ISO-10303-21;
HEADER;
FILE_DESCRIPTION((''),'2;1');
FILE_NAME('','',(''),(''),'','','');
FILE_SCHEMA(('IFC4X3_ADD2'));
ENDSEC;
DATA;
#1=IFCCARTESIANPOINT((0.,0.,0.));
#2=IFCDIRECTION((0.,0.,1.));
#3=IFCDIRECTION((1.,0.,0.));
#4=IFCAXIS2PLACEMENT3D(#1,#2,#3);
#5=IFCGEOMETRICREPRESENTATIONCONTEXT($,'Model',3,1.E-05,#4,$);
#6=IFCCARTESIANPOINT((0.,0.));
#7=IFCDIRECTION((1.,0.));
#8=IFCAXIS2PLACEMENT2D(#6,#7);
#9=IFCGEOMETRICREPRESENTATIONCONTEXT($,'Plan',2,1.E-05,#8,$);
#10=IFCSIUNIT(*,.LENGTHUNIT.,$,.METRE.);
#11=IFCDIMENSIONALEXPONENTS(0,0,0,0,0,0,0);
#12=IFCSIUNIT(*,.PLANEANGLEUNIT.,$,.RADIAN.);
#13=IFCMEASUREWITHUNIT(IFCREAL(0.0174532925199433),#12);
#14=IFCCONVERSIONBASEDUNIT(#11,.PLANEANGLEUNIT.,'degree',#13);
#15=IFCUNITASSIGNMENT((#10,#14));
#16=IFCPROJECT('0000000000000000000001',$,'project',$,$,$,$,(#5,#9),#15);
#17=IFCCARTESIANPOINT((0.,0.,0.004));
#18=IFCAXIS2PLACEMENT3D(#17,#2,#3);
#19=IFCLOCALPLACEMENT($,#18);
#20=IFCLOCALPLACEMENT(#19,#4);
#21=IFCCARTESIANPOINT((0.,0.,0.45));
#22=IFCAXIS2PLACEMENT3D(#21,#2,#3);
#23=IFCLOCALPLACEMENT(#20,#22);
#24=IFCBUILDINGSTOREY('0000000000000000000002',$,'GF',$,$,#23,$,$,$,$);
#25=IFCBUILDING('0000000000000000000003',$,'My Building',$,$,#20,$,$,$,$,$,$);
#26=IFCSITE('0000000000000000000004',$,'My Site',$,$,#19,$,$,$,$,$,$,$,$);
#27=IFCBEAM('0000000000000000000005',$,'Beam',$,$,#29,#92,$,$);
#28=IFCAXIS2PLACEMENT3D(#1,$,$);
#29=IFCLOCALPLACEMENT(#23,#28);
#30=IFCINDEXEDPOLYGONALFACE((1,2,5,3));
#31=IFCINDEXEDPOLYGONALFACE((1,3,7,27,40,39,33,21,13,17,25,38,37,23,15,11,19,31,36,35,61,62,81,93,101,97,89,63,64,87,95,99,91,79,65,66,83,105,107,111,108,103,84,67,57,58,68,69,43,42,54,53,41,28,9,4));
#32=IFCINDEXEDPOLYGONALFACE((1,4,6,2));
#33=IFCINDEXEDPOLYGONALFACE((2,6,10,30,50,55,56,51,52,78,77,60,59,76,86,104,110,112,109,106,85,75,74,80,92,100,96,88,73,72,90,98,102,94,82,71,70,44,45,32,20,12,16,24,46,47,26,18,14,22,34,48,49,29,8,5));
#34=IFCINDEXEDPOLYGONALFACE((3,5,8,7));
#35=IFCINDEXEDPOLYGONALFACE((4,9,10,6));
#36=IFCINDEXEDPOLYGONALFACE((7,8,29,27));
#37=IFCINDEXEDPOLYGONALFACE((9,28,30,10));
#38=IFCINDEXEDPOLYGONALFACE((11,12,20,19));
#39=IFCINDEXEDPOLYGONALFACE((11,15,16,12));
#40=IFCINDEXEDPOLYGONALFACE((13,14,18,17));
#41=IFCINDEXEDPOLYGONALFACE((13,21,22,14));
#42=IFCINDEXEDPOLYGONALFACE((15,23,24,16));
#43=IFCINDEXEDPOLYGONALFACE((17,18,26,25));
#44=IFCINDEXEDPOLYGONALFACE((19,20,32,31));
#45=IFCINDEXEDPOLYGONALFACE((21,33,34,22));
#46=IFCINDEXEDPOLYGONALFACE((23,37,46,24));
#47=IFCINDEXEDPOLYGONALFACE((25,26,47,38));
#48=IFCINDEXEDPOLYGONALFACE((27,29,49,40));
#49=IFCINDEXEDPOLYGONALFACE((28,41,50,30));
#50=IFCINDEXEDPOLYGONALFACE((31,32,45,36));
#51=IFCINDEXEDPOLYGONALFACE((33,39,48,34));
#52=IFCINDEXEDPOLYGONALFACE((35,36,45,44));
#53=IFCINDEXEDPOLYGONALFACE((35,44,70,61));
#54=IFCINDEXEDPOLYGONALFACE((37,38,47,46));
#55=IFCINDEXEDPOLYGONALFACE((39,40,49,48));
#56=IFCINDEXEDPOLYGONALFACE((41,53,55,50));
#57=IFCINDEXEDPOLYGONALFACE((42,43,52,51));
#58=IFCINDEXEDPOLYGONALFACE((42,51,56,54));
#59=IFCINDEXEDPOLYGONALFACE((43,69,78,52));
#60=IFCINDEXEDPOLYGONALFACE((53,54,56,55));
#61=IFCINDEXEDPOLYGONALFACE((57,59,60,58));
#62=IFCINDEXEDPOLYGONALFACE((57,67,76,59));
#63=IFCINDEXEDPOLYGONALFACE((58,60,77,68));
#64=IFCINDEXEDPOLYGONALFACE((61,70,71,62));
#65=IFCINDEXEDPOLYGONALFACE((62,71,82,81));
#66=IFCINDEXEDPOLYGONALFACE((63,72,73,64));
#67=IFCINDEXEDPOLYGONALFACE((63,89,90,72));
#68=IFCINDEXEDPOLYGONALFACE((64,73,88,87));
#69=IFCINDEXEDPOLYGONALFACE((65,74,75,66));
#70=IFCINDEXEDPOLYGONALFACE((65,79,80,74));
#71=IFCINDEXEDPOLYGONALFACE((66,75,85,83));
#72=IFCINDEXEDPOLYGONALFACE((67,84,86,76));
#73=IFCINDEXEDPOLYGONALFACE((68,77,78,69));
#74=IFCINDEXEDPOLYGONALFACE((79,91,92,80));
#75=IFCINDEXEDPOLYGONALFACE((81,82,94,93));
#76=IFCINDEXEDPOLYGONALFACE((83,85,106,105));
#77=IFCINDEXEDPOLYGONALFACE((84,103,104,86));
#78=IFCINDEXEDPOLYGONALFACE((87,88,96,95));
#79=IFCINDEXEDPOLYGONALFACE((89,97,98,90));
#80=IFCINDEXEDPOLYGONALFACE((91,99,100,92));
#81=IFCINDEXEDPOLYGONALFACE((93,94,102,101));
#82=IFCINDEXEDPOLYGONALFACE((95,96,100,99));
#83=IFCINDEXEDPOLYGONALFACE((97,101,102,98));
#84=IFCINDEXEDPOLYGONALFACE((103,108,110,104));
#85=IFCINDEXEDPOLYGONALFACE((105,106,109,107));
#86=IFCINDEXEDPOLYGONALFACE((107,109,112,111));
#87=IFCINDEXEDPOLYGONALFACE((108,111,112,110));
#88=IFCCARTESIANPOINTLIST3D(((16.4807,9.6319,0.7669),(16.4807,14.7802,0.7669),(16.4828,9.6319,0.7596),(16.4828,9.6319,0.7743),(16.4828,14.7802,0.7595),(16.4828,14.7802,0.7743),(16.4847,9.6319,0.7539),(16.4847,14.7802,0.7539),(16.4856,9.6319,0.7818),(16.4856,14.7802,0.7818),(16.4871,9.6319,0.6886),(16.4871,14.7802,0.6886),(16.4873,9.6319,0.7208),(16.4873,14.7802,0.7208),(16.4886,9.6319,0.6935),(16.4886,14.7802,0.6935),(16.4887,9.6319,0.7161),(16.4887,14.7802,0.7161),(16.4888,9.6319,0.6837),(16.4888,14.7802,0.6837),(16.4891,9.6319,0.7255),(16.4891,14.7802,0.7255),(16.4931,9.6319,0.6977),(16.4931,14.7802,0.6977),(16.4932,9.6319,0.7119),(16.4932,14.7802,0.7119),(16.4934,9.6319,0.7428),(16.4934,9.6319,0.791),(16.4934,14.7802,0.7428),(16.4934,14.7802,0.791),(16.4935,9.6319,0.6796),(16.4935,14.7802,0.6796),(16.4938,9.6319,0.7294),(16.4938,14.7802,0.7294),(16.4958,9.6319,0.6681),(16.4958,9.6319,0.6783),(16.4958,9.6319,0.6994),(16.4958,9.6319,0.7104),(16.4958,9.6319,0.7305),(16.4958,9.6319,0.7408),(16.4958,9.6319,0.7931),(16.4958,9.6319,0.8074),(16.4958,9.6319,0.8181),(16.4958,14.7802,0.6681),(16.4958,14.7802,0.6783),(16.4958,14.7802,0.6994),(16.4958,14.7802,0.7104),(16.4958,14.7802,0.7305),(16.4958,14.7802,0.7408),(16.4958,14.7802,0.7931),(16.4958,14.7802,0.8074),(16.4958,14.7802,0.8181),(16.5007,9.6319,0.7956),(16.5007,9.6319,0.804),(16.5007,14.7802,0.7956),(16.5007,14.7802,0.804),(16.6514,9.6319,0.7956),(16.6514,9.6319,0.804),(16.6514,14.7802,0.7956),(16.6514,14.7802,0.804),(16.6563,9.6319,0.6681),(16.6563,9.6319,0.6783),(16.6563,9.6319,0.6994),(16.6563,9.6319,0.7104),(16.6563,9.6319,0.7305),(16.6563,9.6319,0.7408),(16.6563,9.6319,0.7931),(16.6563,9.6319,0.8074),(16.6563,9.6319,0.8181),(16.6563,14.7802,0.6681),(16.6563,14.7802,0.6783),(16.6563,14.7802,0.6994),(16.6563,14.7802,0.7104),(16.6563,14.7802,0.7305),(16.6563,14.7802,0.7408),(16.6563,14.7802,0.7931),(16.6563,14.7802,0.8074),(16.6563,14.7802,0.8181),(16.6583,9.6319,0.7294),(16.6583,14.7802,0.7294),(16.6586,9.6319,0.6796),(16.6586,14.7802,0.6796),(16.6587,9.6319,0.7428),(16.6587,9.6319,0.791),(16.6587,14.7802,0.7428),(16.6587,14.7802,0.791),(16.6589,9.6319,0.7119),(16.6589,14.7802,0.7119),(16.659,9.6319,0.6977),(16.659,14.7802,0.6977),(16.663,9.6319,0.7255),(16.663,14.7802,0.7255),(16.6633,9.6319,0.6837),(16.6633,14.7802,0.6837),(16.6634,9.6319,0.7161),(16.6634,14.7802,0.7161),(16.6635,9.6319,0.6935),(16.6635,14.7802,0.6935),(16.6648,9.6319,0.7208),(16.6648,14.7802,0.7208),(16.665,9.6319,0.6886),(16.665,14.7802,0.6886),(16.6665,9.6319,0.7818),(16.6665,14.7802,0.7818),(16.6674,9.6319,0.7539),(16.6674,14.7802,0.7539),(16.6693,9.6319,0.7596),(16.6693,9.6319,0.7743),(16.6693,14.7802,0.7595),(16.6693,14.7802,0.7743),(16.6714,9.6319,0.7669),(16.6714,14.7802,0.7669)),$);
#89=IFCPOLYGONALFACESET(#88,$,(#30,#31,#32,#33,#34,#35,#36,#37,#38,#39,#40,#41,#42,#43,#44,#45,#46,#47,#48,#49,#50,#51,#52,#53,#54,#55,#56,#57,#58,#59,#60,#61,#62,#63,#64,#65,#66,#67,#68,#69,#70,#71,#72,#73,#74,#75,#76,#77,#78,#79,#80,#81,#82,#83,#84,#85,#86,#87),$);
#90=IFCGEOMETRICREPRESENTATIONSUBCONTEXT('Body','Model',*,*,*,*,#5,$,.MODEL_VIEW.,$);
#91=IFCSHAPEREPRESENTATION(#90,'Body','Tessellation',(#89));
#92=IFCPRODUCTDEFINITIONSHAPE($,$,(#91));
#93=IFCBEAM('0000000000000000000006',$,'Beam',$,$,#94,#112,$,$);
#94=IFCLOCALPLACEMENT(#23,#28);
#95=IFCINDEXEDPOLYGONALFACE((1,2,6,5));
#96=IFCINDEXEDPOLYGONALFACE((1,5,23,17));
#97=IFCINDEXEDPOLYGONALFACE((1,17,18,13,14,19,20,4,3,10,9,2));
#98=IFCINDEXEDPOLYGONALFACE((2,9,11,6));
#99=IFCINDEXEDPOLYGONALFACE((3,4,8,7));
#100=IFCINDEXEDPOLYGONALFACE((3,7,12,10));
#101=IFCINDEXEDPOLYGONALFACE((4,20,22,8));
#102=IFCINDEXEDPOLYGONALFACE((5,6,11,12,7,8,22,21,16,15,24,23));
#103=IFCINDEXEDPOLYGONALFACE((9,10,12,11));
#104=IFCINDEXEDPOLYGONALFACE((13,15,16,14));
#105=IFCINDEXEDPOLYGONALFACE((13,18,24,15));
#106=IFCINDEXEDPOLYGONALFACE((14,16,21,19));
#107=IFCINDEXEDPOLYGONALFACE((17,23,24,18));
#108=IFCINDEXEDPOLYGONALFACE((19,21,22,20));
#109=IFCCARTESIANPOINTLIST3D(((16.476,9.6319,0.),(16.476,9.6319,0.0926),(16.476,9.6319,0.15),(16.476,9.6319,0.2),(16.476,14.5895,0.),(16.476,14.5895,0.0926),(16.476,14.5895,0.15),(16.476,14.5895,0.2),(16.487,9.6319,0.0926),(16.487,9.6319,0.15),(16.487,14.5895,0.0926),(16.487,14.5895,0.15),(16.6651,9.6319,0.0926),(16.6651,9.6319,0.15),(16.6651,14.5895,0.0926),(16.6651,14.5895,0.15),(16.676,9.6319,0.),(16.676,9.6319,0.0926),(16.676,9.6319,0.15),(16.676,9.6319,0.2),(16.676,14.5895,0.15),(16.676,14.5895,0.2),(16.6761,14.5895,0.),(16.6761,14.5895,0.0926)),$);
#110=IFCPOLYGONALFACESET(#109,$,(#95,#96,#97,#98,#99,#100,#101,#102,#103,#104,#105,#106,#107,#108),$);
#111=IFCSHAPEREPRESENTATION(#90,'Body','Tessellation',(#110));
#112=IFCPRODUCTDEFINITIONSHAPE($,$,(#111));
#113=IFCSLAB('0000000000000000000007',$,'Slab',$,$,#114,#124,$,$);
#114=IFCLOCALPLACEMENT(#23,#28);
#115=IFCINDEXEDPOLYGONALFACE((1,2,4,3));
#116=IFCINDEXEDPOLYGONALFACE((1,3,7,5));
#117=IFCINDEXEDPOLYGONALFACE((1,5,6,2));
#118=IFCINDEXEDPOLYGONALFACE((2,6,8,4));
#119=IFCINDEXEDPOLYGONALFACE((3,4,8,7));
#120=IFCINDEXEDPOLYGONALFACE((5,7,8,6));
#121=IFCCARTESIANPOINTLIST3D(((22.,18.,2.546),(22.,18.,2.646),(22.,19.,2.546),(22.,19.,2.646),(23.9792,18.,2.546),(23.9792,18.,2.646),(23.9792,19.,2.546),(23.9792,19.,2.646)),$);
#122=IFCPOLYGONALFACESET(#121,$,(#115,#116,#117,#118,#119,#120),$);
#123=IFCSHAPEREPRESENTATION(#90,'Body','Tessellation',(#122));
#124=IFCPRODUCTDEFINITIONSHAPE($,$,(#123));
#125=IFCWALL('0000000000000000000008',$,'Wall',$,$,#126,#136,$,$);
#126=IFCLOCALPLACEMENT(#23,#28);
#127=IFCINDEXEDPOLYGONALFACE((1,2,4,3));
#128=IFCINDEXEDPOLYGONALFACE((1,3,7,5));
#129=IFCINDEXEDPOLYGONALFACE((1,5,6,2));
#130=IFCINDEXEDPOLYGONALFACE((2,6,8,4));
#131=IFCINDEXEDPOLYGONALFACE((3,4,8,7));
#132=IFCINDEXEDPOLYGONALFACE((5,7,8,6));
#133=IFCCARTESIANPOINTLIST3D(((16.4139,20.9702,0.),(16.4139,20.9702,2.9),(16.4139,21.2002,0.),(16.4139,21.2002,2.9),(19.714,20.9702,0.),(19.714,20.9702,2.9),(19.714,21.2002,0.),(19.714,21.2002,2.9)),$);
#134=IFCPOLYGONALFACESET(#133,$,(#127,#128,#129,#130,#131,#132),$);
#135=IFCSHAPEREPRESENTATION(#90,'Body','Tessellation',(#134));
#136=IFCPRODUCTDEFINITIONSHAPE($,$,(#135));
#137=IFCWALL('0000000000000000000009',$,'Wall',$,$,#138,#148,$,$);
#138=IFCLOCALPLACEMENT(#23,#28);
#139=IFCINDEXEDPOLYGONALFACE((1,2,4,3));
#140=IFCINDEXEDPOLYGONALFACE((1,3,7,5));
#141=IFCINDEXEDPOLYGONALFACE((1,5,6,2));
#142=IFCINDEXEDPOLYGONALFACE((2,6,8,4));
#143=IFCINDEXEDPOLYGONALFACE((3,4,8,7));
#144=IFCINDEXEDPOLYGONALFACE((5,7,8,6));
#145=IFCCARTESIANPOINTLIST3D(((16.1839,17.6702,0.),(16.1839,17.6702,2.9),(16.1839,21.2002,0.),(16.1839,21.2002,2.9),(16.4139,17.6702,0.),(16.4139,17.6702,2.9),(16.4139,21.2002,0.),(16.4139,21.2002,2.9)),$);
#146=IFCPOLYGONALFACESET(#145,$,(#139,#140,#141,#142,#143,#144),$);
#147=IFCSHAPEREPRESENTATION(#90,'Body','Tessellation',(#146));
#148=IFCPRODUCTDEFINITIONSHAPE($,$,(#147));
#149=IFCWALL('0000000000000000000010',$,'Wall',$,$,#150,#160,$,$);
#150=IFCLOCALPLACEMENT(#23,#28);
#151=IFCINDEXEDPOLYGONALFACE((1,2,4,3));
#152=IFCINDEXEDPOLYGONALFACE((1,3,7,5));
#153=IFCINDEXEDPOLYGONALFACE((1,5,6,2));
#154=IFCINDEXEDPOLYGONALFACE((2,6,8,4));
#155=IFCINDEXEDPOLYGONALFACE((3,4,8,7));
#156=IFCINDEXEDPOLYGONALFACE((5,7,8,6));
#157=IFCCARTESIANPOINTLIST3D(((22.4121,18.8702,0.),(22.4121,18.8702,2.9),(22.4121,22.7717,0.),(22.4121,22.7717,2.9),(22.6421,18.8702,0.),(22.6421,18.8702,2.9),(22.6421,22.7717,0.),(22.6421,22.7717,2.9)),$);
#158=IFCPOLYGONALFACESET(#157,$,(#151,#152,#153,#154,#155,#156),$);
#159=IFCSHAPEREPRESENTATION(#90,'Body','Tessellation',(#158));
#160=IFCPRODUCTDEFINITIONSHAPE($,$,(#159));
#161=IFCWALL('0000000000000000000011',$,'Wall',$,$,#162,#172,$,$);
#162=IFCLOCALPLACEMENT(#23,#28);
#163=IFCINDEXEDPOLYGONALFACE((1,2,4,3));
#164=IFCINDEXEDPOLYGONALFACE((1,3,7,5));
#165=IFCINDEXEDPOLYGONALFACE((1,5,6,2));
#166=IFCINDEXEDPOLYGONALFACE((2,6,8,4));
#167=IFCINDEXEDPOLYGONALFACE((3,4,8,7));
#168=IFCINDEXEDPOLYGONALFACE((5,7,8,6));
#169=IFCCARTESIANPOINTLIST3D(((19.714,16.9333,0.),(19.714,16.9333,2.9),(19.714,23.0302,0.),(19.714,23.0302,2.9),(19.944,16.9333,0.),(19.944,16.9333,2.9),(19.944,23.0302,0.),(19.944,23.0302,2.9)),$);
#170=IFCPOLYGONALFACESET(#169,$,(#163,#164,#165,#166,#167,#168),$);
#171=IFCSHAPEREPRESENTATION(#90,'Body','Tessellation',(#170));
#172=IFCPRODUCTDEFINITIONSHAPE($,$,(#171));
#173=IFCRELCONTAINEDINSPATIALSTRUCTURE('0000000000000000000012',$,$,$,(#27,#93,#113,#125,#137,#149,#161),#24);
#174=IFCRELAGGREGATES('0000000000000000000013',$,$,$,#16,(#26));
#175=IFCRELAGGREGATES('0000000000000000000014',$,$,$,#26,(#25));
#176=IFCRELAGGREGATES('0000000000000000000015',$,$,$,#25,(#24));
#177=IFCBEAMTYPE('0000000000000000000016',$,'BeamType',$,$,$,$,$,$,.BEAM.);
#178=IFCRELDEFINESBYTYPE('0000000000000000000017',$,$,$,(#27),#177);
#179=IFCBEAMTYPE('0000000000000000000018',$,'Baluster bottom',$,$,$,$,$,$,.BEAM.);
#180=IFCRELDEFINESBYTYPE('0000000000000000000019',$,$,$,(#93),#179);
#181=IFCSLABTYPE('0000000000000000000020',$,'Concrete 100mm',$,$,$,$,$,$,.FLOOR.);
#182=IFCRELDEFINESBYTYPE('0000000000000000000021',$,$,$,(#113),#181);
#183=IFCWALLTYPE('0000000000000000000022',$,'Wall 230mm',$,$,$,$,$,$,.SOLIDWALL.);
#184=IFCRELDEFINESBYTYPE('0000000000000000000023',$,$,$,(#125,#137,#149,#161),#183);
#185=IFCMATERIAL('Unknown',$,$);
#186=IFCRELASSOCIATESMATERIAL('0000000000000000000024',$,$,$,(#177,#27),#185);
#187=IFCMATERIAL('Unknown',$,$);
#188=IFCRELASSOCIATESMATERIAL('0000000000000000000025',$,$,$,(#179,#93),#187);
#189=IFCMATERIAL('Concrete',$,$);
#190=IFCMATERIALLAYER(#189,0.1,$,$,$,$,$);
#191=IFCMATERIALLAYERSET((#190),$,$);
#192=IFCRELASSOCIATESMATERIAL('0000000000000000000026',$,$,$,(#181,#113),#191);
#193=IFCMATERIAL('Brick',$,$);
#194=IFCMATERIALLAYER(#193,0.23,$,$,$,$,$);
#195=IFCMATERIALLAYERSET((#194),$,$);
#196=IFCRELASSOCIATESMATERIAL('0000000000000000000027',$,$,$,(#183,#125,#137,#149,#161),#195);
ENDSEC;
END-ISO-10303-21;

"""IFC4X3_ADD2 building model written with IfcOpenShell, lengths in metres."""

from ifc_helpers import new_model, entity, si_unit, converted_unit, frame, origin_with_axes, origin_2d_with_axis, place, context, subcontext, project, spatial, line, indexed_curve, outline, extrude, material, layer, layer_set, layer_usage, material_profile, profile_set, profile_usage, type_object, element, save


model = new_model("IFC4X3_ADD2")

# Units and contexts
model_context = context("Model", 3, precision=1e-05, world=origin_with_axes())
plan_context = context("Plan", 2, precision=1e-05, world=origin_2d_with_axis())
body_context_1 = subcontext(model_context, "Body", "Model", "MODEL_VIEW")
ifc_project = project(units=[si_unit("LENGTHUNIT", "METRE"), converted_unit("PLANEANGLEUNIT", "degree", entity("IfcReal", 0.0174532925199433), si_unit("PLANEANGLEUNIT", "RADIAN"), dimensions=[0, 0, 0, 0, 0, 0, 0])], contexts=[model_context, plan_context])

# Site, building, storey
site_placement = place(None, frame((0.0, 0.0, 0.004), z_axis=(0.0, 0.0, 1.0), x_axis=(1.0, 0.0, 0.0)))
site = spatial("IfcSite", under=ifc_project, at=site_placement, Name="My Site")
building_placement = place(site_placement, origin_with_axes())
building = spatial("IfcBuilding", under=site, at=building_placement, Name="My Building")
storey_placement = place(building_placement, frame((0.0, 0.0, 0.45), z_axis=(0.0, 0.0, 1.0), x_axis=(1.0, 0.0, 0.0)))
storey = spatial("IfcBuildingStorey", under=building, at=storey_placement, Name="GF")

# Beams
ifc_material_1 = material(Name="Unknown")
ifc_material_profile_1 = material_profile(ifc_material_1, outline(indexed_curve([(0.0803, 0.0102), (0.0826, 0.0116), (0.0872, 0.0156), (0.0889, 0.0205), (0.0874, 0.0254), (0.083, 0.0297), (0.0803, 0.0314), (0.0803, 0.0423), (0.0828, 0.0439), (0.0873, 0.048), (0.0888, 0.0528), (0.087, 0.0574), (0.0822, 0.0613), (0.0803, 0.0624), (0.0803, 0.0727), (0.0827, 0.0747), (0.0914, 0.0858), (0.0933, 0.0915), (0.0953, 0.0989), (0.0933, 0.1062), (0.0904, 0.1137), (0.0827, 0.123), (0.0803, 0.125), (0.0754, 0.1276), (0.0754, 0.1359), (0.0803, 0.1393), (0.0803, 0.15), (-0.0803, 0.15), (-0.0803, 0.1393), (-0.0754, 0.1359), (-0.0754, 0.1276), (-0.0803, 0.125), (-0.0827, 0.123), (-0.0904, 0.1137), (-0.0933, 0.1062), (-0.0953, 0.0989), (-0.0933, 0.0915), (-0.0914, 0.0858), (-0.0827, 0.0747), (-0.0803, 0.0727), (-0.0803, 0.0624), (-0.0822, 0.0613), (-0.087, 0.0574), (-0.0888, 0.0528), (-0.0873, 0.048), (-0.0828, 0.0439), (-0.0803, 0.0423), (-0.0803, 0.0314), (-0.083, 0.0297), (-0.0874, 0.0254), (-0.0889, 0.0205), (-0.0872, 0.0157), (-0.0826, 0.0116), (-0.0803, 0.0102), (-0.0803, 0.0), (0.0803, 0.0), (0.0803, 0.0102)])))
ifc_profile_set_1 = profile_set([ifc_material_profile_1])
ifc_profile_usage_1 = profile_usage(ifc_profile_set_1, cardinal=5)
beam_type_1 = type_object("IfcBeamType", Name="BeamType", PredefinedType="BEAM", material=ifc_profile_set_1)
beam_1_placement = place(storey_placement, frame((16.576, 14.7802, 0.6681), z_axis=(0.0, -1.0, 0.0), x_axis=(1.0, 0.0, 0.0)))
element("IfcBeam", 1, at=beam_1_placement, inside=storey, type_object=beam_type_1, material=ifc_profile_usage_1, Name="Beam", context=body_context_1, shape_type="SweptSolid", body=[
    extrude(outline(indexed_curve([(0.0803, 0.0102), (0.0826, 0.0116), (0.0872, 0.0156), (0.0889, 0.0205), (0.0874, 0.0254), (0.083, 0.0297), (0.0803, 0.0314), (0.0803, 0.0423), (0.0828, 0.0439), (0.0873, 0.048), (0.0888, 0.0528), (0.087, 0.0574), (0.0822, 0.0613), (0.0803, 0.0624), (0.0803, 0.0727), (0.0827, 0.0747), (0.0914, 0.0858), (0.0933, 0.0915), (0.0953, 0.0989), (0.0933, 0.1062), (0.0904, 0.1137), (0.0827, 0.123), (0.0803, 0.125), (0.0754, 0.1276), (0.0754, 0.1359), (0.0803, 0.1393), (0.0803, 0.15), (-0.0803, 0.15), (-0.0803, 0.1393), (-0.0754, 0.1359), (-0.0754, 0.1276), (-0.0803, 0.125), (-0.0827, 0.123), (-0.0904, 0.1137), (-0.0933, 0.1062), (-0.0953, 0.0989), (-0.0933, 0.0915), (-0.0914, 0.0858), (-0.0827, 0.0747), (-0.0803, 0.0727), (-0.0803, 0.0624), (-0.0822, 0.0613), (-0.087, 0.0574), (-0.0888, 0.0528), (-0.0873, 0.048), (-0.0828, 0.0439), (-0.0803, 0.0423), (-0.0803, 0.0314), (-0.083, 0.0297), (-0.0874, 0.0254), (-0.0889, 0.0205), (-0.0872, 0.0157), (-0.0826, 0.0116), (-0.0803, 0.0102), (-0.0803, 0.0), (0.0803, 0.0), (0.0803, 0.0102)])), origin_with_axes(), (0.0, 0.0, 1.0), 5.1484),
])
ifc_material_2 = material(Name="Unknown")
ifc_material_profile_2 = material_profile(ifc_material_2, outline(indexed_curve([(0.0891, 0.15), (0.1, 0.15), (0.1, 0.2), (-0.1, 0.2), (-0.1, 0.15), (-0.0891, 0.15), (-0.0891, 0.0926), (-0.1, 0.0926), (-0.1, 0.0), (0.1, 0.0), (0.1, 0.0926), (0.0891, 0.0926), (0.0891, 0.15)])))
ifc_profile_set_2 = profile_set([ifc_material_profile_2])
ifc_profile_usage_2 = profile_usage(ifc_profile_set_2, cardinal=5)
beam_type_2 = type_object("IfcBeamType", Name="Baluster bottom", PredefinedType="BEAM", material=ifc_profile_set_2)
beam_2_placement = place(storey_placement, frame((16.576, 14.5895, 0.0), z_axis=(0.0, -1.0, 0.0), x_axis=(1.0, 0.0, 0.0)))
element("IfcBeam", 2, at=beam_2_placement, inside=storey, type_object=beam_type_2, material=ifc_profile_usage_2, Name="Beam", context=body_context_1, shape_type="SweptSolid", body=[
    extrude(outline(indexed_curve([(0.0891, 0.15), (0.1, 0.15), (0.1, 0.2), (-0.1, 0.2), (-0.1, 0.15), (-0.0891, 0.15), (-0.0891, 0.0926), (-0.1, 0.0926), (-0.1, 0.0), (0.1, 0.0), (0.1, 0.0926), (0.0891, 0.0926), (0.0891, 0.15)])), origin_with_axes(), (0.0, 0.0, 1.0), 4.9577),
])

# Slab
ifc_material_3 = material(Name="Concrete")
ifc_layer_1 = layer(ifc_material_3, 0.1)
ifc_layer_set_1 = layer_set([ifc_layer_1])
slab_type_1 = type_object("IfcSlabType", Name="Concrete 100mm", PredefinedType="FLOOR", material=ifc_layer_set_1)
ifc_layer_usage_1 = layer_usage(ifc_layer_set_1, "AXIS3", "POSITIVE", 0.0)
slab_1_placement = place(storey_placement, frame((22.0, 18.0, 2.546), z_axis=(0.0, 0.0, 1.0), x_axis=(1.0, 0.0, 0.0)))
element("IfcSlab", 3, at=slab_1_placement, inside=storey, type_object=slab_type_1, material=ifc_layer_usage_1, Name="Slab", context=body_context_1, shape_type="SweptSolid", body=[
    extrude(outline(indexed_curve([(0.0, 0.0), (1.9792, 0.0), (1.9792, 1.0), (0.0, 1.0)], segments=[line(4, 1), line(1, 2), line(2, 3), line(3, 4)], self_intersect=False)), None, (0.0, 0.0, 1.0), 0.1),
])

# Walls
ifc_material_4 = material(Name="Brick")
ifc_layer_2 = layer(ifc_material_4, 0.23)
ifc_layer_set_2 = layer_set([ifc_layer_2])
ifc_layer_usage_2 = layer_usage(ifc_layer_set_2, "AXIS2", "POSITIVE", 0.0)
wall_type = type_object("IfcWallType", Name="Wall 230mm", PredefinedType="SOLIDWALL", material=ifc_layer_set_2)
wall_1_placement = place(storey_placement, frame((19.714, 21.2002, 0.0), z_axis=(0.0, 0.0, 1.0), x_axis=(-1.0, 0.0, 0.0)))
element("IfcWall", 4, at=wall_1_placement, inside=storey, type_object=wall_type, material=ifc_layer_usage_2, Name="Wall", context=body_context_1, shape_type="SweptSolid", body=[
    extrude(outline(indexed_curve([(0.0, 0.0), (0.0, 0.23), (3.3, 0.23), (3.3, 0.0), (0.0, 0.0)], self_intersect=False)), origin_with_axes(), (0.0, 0.0, 1.0), 2.9),
])
ifc_layer_usage_3 = layer_usage(ifc_layer_set_2, "AXIS2", "POSITIVE", 0.0)
wall_2_placement = place(storey_placement, frame((16.4139, 17.6702, 0.0), z_axis=(0.0, 0.0, 1.0), x_axis=(0.000001, 1.0, 0.0)))
element("IfcWall", 5, at=wall_2_placement, inside=storey, type_object=wall_type, material=ifc_layer_usage_3, Name="Wall", context=body_context_1, shape_type="SweptSolid", body=[
    extrude(outline(indexed_curve([(0.0, 0.0), (0.0, 0.23), (3.53, 0.23), (3.53, 0.0), (0.0, 0.0)], self_intersect=False)), origin_with_axes(), (0.0, 0.0, 1.0), 2.9),
])
ifc_layer_usage_4 = layer_usage(ifc_layer_set_2, "AXIS2", "POSITIVE", 0.0)
wall_3_placement = place(storey_placement, frame((22.6421, 18.8702, 0.0), z_axis=(0.0, 0.0, 1.0), x_axis=(0.000001, 1.0, 0.0)))
element("IfcWall", 6, at=wall_3_placement, inside=storey, type_object=wall_type, material=ifc_layer_usage_4, Name="Wall", context=body_context_1, shape_type="SweptSolid", body=[
    extrude(outline(indexed_curve([(0.0, 0.0), (0.0, 0.23), (3.9015, 0.23), (3.9015, 0.0), (0.0, 0.0)], self_intersect=False)), origin_with_axes(), (0.0, 0.0, 1.0), 2.9),
])
ifc_layer_usage_5 = layer_usage(ifc_layer_set_2, "AXIS2", "POSITIVE", 0.0)
wall_4_placement = place(storey_placement, frame((19.944, 16.9333, 0.0), z_axis=(0.0, 0.0, 1.0), x_axis=(0.000001, 1.0, 0.0)))
element("IfcWall", 7, at=wall_4_placement, inside=storey, type_object=wall_type, material=ifc_layer_usage_5, Name="Wall", context=body_context_1, shape_type="SweptSolid", body=[
    extrude(outline(indexed_curve([(0.0, 0.0), (0.0, 0.23), (6.0969, 0.23), (6.0969, 0.0), (0.0, 0.0)], self_intersect=False)), origin_with_axes(), (0.0, 0.0, 1.0), 2.9),
])

save(model, "model.ifc")
